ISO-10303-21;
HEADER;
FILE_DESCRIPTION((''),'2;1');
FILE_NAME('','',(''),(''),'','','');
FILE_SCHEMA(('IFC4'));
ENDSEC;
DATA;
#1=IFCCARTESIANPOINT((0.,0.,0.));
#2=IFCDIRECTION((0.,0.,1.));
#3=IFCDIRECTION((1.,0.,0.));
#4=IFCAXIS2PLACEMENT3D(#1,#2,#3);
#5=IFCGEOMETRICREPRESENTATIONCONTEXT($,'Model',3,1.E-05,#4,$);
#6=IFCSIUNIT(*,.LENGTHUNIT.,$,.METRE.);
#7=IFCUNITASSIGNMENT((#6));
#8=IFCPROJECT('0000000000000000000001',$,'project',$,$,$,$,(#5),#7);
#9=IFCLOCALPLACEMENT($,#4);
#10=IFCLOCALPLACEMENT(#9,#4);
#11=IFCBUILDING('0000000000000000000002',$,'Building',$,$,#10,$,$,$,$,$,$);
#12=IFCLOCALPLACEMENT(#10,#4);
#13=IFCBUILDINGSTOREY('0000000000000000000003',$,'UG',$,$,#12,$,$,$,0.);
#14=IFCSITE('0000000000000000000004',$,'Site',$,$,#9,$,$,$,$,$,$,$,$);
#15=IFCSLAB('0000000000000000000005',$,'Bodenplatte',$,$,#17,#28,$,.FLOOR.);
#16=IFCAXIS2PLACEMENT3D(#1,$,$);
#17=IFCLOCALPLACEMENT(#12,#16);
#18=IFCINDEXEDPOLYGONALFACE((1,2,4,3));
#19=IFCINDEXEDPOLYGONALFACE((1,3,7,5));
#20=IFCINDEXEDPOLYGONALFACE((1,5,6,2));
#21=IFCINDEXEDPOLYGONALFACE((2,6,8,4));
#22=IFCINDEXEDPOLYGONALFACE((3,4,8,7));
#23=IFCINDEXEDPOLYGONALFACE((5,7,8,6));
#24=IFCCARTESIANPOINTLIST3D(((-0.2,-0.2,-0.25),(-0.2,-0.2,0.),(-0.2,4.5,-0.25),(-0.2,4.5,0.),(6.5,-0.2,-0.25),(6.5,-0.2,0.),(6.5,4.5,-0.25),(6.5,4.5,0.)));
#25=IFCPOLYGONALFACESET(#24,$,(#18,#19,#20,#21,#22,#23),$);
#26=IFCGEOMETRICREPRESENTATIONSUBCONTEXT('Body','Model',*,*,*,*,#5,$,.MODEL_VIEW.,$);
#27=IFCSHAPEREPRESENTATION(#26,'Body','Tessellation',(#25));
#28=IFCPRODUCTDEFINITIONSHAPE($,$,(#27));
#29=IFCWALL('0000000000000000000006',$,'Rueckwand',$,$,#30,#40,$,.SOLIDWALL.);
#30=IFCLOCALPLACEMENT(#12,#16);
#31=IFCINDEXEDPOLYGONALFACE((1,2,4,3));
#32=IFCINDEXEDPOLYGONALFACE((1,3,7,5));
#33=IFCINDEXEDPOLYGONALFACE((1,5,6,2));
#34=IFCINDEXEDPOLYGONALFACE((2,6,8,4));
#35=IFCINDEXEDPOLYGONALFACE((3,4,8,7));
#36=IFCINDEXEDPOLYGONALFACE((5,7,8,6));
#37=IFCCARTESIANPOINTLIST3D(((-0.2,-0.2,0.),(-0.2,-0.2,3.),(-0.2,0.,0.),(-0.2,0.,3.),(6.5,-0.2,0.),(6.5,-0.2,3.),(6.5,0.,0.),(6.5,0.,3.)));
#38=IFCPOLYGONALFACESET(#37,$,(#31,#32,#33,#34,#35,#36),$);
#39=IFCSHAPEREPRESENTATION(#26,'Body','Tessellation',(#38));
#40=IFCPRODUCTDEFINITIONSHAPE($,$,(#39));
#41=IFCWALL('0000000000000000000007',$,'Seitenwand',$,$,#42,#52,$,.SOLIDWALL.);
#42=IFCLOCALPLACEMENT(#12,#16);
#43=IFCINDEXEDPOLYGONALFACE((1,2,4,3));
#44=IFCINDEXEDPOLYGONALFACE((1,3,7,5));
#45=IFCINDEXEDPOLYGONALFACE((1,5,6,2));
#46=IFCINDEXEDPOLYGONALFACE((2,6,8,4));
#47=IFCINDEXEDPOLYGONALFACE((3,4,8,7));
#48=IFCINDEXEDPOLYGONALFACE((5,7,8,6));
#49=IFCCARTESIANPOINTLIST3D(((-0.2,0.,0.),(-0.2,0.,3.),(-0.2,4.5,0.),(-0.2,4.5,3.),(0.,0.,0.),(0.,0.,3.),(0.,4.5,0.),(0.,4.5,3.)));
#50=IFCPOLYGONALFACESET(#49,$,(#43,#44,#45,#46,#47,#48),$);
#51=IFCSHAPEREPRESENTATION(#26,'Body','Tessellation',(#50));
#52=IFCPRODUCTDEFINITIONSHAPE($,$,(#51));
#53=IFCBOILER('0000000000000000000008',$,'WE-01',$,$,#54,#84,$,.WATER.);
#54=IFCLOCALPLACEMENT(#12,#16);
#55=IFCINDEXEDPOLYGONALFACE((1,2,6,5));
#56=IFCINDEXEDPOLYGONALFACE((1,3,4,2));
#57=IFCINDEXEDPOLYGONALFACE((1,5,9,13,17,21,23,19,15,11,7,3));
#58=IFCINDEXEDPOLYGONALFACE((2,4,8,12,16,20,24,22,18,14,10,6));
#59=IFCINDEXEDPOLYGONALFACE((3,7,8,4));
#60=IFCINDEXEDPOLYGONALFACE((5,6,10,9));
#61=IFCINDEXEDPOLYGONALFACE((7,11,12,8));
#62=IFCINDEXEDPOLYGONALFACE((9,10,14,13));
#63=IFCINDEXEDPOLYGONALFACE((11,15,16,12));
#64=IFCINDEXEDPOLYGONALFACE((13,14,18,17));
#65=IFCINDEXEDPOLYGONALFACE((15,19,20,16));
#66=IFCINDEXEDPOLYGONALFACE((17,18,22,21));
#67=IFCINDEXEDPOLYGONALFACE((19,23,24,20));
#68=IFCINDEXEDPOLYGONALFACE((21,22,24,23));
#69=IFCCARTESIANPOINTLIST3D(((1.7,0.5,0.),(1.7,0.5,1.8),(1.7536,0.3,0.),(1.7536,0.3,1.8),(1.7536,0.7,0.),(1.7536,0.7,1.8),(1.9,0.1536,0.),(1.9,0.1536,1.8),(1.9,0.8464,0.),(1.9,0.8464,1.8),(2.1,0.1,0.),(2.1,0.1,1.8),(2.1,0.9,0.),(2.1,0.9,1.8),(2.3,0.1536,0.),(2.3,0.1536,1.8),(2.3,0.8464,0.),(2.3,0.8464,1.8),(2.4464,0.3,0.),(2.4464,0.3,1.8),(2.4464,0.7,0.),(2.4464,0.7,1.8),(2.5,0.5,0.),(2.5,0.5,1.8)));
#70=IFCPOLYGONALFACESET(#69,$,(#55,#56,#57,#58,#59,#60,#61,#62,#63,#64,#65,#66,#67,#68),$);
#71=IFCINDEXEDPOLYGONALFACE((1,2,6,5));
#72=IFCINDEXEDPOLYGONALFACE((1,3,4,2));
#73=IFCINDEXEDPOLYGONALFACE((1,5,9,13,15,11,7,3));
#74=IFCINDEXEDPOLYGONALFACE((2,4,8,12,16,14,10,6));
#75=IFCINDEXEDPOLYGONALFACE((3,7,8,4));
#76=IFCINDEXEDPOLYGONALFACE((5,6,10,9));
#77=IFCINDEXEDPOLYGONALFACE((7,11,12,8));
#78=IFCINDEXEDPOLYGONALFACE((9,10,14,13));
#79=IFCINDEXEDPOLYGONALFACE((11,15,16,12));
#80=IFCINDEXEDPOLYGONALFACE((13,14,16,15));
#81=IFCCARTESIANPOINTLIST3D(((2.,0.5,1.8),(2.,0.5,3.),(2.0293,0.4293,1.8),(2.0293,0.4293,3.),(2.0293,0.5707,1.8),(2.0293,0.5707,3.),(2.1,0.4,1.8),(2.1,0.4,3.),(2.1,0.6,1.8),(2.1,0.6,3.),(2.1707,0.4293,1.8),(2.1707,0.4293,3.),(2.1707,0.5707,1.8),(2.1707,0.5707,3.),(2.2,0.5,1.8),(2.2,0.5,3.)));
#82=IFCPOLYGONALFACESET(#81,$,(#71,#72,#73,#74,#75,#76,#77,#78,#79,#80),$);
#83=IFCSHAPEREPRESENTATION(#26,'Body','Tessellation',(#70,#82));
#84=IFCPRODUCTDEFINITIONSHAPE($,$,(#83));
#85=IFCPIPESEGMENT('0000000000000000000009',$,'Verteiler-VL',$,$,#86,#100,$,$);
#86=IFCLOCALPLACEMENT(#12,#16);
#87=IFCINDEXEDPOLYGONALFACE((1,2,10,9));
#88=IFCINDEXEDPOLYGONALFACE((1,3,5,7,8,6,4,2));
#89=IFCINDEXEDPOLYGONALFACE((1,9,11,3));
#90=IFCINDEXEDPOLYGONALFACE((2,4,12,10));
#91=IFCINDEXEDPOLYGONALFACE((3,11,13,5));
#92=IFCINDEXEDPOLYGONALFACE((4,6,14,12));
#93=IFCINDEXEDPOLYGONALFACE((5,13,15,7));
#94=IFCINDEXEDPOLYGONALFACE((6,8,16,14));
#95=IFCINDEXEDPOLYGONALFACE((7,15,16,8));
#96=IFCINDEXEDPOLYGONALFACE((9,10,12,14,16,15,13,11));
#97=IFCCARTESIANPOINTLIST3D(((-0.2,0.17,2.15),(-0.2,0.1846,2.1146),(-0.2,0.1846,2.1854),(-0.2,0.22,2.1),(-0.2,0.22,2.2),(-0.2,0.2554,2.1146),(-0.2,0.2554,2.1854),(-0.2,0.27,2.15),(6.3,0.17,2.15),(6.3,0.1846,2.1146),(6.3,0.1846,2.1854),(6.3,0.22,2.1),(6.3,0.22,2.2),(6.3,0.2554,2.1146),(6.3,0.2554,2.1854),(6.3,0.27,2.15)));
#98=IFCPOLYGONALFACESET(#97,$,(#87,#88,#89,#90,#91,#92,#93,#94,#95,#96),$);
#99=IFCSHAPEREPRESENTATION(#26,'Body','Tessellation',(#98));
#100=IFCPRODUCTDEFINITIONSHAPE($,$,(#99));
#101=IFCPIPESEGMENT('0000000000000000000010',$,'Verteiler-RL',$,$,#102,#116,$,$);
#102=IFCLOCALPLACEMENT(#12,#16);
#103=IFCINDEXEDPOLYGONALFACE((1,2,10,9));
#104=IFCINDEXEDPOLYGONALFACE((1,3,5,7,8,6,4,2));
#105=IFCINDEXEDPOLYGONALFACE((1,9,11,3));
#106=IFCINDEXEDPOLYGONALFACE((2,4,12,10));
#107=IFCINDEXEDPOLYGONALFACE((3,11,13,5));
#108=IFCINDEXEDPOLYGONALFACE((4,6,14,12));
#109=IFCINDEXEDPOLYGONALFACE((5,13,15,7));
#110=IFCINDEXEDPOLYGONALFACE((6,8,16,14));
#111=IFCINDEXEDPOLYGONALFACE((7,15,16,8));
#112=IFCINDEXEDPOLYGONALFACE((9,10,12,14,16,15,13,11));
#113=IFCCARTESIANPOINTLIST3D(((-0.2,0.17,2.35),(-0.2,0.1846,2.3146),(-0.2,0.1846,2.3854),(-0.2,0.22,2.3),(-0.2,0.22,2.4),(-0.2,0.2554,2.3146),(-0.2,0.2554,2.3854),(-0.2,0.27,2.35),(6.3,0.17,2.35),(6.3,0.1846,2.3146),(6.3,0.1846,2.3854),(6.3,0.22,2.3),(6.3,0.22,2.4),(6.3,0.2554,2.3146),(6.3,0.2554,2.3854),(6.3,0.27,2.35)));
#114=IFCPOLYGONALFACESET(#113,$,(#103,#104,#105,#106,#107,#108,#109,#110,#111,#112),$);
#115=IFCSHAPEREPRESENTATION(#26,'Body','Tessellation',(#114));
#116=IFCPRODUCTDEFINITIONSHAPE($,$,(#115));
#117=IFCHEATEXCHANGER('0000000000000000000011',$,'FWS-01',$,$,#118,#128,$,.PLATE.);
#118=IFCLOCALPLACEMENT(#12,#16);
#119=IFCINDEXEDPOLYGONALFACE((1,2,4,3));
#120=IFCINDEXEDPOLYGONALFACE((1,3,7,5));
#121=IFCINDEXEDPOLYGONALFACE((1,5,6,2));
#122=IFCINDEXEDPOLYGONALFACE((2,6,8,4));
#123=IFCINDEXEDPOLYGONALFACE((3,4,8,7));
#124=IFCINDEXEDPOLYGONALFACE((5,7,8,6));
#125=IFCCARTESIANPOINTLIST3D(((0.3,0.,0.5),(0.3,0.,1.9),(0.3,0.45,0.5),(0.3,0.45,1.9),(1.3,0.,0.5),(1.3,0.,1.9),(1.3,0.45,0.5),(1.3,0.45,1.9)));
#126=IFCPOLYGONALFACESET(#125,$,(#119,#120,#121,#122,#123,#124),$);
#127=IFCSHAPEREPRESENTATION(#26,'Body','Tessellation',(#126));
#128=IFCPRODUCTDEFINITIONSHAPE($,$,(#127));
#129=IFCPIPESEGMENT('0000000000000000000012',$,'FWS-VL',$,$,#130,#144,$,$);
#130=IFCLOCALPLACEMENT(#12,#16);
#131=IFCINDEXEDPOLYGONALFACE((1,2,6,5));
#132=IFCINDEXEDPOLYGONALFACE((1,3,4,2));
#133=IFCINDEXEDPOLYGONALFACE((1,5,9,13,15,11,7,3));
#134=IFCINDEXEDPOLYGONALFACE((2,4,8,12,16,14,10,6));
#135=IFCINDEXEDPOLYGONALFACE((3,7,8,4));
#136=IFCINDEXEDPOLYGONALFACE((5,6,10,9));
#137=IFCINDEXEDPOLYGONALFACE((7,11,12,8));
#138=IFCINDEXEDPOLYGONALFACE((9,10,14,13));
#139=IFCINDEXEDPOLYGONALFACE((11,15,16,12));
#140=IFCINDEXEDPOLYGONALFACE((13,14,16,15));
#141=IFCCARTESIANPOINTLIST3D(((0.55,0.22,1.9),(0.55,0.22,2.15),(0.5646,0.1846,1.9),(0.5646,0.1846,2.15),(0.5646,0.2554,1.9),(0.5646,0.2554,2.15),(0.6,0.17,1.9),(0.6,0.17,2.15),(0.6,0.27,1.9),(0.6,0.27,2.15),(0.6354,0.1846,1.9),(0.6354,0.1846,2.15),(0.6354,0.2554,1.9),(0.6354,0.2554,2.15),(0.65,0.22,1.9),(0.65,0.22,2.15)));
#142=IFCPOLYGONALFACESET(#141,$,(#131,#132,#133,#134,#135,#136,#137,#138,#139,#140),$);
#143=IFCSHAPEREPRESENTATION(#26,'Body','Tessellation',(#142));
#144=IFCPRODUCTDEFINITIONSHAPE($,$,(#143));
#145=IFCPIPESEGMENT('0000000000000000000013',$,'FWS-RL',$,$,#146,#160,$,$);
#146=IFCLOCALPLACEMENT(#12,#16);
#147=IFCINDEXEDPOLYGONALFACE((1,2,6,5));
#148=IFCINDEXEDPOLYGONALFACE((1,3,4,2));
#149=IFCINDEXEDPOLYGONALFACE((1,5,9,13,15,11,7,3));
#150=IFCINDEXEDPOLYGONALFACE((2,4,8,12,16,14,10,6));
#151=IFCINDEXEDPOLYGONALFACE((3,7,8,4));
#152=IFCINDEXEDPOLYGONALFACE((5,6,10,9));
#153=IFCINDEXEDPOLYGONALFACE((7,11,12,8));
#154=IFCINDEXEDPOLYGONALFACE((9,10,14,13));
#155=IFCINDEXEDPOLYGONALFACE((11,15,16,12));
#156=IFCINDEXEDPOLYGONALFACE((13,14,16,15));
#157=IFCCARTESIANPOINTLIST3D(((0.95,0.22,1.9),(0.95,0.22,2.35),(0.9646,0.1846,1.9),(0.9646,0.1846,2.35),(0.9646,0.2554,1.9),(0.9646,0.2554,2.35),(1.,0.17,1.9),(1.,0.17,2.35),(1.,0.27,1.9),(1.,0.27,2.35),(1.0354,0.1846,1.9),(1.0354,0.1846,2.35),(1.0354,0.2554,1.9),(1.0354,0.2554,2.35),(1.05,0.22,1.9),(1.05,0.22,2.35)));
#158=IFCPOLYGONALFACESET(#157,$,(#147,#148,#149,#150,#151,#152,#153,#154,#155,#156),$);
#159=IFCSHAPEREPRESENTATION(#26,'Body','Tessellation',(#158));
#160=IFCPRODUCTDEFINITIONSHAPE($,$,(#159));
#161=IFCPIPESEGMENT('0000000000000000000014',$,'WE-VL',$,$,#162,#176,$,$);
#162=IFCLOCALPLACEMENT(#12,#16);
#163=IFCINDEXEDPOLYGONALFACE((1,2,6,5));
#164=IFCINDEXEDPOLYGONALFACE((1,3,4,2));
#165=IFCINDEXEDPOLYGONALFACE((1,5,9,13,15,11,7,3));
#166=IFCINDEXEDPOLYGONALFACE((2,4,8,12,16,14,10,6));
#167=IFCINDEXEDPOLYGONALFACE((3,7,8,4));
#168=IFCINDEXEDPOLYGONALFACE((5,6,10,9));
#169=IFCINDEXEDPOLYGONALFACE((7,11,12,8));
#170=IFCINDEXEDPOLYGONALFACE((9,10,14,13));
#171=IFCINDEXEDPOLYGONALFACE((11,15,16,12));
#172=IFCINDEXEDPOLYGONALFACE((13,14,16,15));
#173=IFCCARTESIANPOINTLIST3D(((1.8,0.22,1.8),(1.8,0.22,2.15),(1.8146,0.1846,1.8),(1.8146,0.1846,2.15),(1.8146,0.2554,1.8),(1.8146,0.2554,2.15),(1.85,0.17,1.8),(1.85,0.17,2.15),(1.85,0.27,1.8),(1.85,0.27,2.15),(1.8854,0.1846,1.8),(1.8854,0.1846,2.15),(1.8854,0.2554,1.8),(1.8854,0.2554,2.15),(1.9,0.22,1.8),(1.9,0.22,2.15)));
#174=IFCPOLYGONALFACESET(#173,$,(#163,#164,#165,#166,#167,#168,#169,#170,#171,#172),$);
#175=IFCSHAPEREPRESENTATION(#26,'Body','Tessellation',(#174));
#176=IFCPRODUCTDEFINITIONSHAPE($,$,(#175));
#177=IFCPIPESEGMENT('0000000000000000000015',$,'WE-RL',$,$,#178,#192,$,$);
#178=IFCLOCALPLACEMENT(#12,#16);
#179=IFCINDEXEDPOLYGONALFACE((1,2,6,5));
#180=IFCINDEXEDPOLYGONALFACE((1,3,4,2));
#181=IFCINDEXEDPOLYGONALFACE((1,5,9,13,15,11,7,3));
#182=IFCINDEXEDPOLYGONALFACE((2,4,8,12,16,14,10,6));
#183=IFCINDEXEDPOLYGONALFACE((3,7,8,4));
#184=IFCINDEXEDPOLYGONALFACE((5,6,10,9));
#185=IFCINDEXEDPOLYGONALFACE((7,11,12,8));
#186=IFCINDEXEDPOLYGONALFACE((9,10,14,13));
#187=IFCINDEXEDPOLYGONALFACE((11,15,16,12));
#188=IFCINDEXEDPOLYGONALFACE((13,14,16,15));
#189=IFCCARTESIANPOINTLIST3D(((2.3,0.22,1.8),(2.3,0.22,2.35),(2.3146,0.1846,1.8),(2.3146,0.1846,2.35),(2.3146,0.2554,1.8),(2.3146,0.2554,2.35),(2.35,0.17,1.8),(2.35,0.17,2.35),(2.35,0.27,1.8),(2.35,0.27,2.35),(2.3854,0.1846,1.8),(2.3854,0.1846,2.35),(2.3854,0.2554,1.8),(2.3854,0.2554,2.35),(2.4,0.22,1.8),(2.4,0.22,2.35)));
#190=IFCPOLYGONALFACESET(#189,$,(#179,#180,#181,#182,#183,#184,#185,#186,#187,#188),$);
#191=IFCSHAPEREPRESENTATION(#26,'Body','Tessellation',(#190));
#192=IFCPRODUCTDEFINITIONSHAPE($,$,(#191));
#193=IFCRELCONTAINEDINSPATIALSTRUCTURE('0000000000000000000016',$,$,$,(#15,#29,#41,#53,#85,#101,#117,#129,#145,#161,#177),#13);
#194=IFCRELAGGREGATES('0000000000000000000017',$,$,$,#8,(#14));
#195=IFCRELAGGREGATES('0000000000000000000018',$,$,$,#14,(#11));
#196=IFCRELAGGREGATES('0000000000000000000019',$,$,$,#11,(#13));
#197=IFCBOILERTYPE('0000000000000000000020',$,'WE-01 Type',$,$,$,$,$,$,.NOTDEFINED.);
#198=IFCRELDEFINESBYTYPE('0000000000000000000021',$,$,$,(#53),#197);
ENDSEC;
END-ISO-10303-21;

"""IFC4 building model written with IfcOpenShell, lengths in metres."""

from ifc_helpers import new_model, si_unit, frame, origin_with_axes, place, context, subcontext, project, spatial, polyline, outline, extrude, type_object, element, save


model = new_model("IFC4")

# Units and contexts
model_context = context("Model", 3, precision=1e-05, world=origin_with_axes())
body_context = subcontext(model_context, "Body", "Model", "MODEL_VIEW")
ifc_project = project(units=[si_unit("LENGTHUNIT", "METRE")], contexts=[model_context])

# Site, building, storey
site_placement = place(None, origin_with_axes())
site = spatial("IfcSite", under=ifc_project, at=site_placement, Name="Site")
building_placement = place(site_placement, origin_with_axes())
building = spatial("IfcBuilding", under=site, at=building_placement, Name="Building")
storey_placement = place(building_placement, origin_with_axes())
storey = spatial("IfcBuildingStorey", under=building, at=storey_placement, Name="UG", Elevation=0.0)

# Slab
slab_placement = place(storey_placement, frame((0.0, 0.0, -0.25), z_axis=(0.0, 0.0, 1.0), x_axis=(1.0, 0.0, 0.0)))
element("IfcSlab", 1, at=slab_placement, inside=storey, Name="Bodenplatte", PredefinedType="FLOOR", context=body_context, shape_type="SweptSolid", body=[
    extrude(outline(polyline([(-0.2, -0.2, 0.0), (6.5, -0.2, 0.0), (6.5, 4.5, 0.0), (-0.2, 4.5, 0.0), (-0.2, -0.2, 0.0)])), origin_with_axes(), (0.0, 0.0, 1.0), 0.25),
])

# Walls
wall_1_placement = place(storey_placement, frame((-0.2, -0.2, 0.0), z_axis=(0.0, 0.0, 1.0), x_axis=(1.0, 0.0, 0.0)))
element("IfcWall", 2, at=wall_1_placement, inside=storey, Name="Rueckwand", PredefinedType="SOLIDWALL", context=body_context, shape_type="SweptSolid", body=[
    extrude(outline(polyline([(0.0, 0.0, 0.0), (6.7, 0.0, 0.0), (6.7, 0.2, 0.0), (0.0, 0.2, 0.0), (0.0, 0.0, 0.0)])), origin_with_axes(), (0.0, 0.0, 1.0), 3.0),
])
wall_2_placement = place(storey_placement, frame((0.0, 0.0, 0.0), z_axis=(0.0, 0.0, 1.0), x_axis=(0.0, 1.0, 0.0)))
element("IfcWall", 3, at=wall_2_placement, inside=storey, Name="Seitenwand", PredefinedType="SOLIDWALL", context=body_context, shape_type="SweptSolid", body=[
    extrude(outline(polyline([(0.0, 0.0, 0.0), (4.5, 0.0, 0.0), (4.5, 0.2, 0.0), (0.0, 0.2, 0.0), (0.0, 0.0, 0.0)])), origin_with_axes(), (0.0, 0.0, 1.0), 3.0),
])

# Boiler
boiler_type = type_object("IfcBoilerType", Name="WE-01 Type", PredefinedType="NOTDEFINED")
boiler_placement = place(storey_placement, origin_with_axes())
element("IfcBoiler", 4, at=boiler_placement, inside=storey, type_object=boiler_type, Name="WE-01", PredefinedType="WATER", context=body_context, shape_type="SweptSolid", body=[
    extrude(outline(polyline([(0.4, 0.0, 0.0), (0.3464, 0.2, 0.0), (0.2, 0.3464, 0.0), (0.0, 0.4, 0.0), (-0.2, 0.3464, 0.0), (-0.3464, 0.2, 0.0), (-0.4, 0.0, 0.0), (-0.3464, -0.2, 0.0), (-0.2, -0.3464, 0.0), (0.0, -0.4, 0.0), (0.2, -0.3464, 0.0), (0.3464, -0.2, 0.0), (0.4, 0.0, 0.0)])), frame((2.1, 0.5, 0.0), z_axis=(0.0, 0.0, 1.0), x_axis=(1.0, 0.0, 0.0)), (0.0, 0.0, 1.0), 1.8),
    extrude(outline(polyline([(0.1, 0.0, 0.0), (0.0707, 0.0707, 0.0), (0.0, 0.1, 0.0), (-0.0707, 0.0707, 0.0), (-0.1, 0.0, 0.0), (-0.0707, -0.0707, 0.0), (0.0, -0.1, 0.0), (0.0707, -0.0707, 0.0), (0.1, 0.0, 0.0)])), frame((2.1, 0.5, 1.8), z_axis=(0.0, 0.0, 1.0), x_axis=(1.0, 0.0, 0.0)), (0.0, 0.0, 1.0), 1.2),
])

# Pipe segments
pipe_segment_1_placement = place(storey_placement, origin_with_axes())
element("IfcPipeSegment", 5, at=pipe_segment_1_placement, inside=storey, Name="Verteiler-VL", context=body_context, shape_type="SweptSolid", body=[
    extrude(outline(polyline([(0.05, 0.0, 0.0), (0.0354, 0.0354, 0.0), (0.0, 0.05, 0.0), (-0.0354, 0.0354, 0.0), (-0.05, 0.0, 0.0), (-0.0354, -0.0354, 0.0), (0.0, -0.05, 0.0), (0.0354, -0.0354, 0.0), (0.05, 0.0, 0.0)])), frame((-0.2, 0.22, 2.15), z_axis=(1.0, 0.0, 0.0), x_axis=(0.0, 1.0, 0.0)), (0.0, 0.0, 1.0), 6.5),
])
pipe_segment_2_placement = place(storey_placement, origin_with_axes())
element("IfcPipeSegment", 6, at=pipe_segment_2_placement, inside=storey, Name="Verteiler-RL", context=body_context, shape_type="SweptSolid", body=[
    extrude(outline(polyline([(0.05, 0.0, 0.0), (0.0354, 0.0354, 0.0), (0.0, 0.05, 0.0), (-0.0354, 0.0354, 0.0), (-0.05, 0.0, 0.0), (-0.0354, -0.0354, 0.0), (0.0, -0.05, 0.0), (0.0354, -0.0354, 0.0), (0.05, 0.0, 0.0)])), frame((-0.2, 0.22, 2.35), z_axis=(1.0, 0.0, 0.0), x_axis=(0.0, 1.0, 0.0)), (0.0, 0.0, 1.0), 6.5),
])

# Heat exchanger
heat_exchanger_placement = place(storey_placement, origin_with_axes())
element("IfcHeatExchanger", 7, at=heat_exchanger_placement, inside=storey, Name="FWS-01", PredefinedType="PLATE", context=body_context, shape_type="SweptSolid", body=[
    extrude(outline(polyline([(0.3, 0.0, 0.0), (1.3, 0.0, 0.0), (1.3, 0.45, 0.0), (0.3, 0.45, 0.0), (0.3, 0.0, 0.0)])), frame((0.0, 0.0, 0.5), z_axis=(0.0, 0.0, 1.0), x_axis=(1.0, 0.0, 0.0)), (0.0, 0.0, 1.0), 1.4),
])

# Pipe segments
pipe_segment_3_placement = place(storey_placement, origin_with_axes())
element("IfcPipeSegment", 8, at=pipe_segment_3_placement, inside=storey, Name="FWS-VL", context=body_context, shape_type="SweptSolid", body=[
    extrude(outline(polyline([(0.05, 0.0, 0.0), (0.0354, 0.0354, 0.0), (0.0, 0.05, 0.0), (-0.0354, 0.0354, 0.0), (-0.05, 0.0, 0.0), (-0.0354, -0.0354, 0.0), (0.0, -0.05, 0.0), (0.0354, -0.0354, 0.0), (0.05, 0.0, 0.0)])), frame((0.6, 0.22, 1.9), z_axis=(0.0, 0.0, 1.0), x_axis=(1.0, 0.0, 0.0)), (0.0, 0.0, 1.0), 0.25),
])
pipe_segment_4_placement = place(storey_placement, origin_with_axes())
element("IfcPipeSegment", 9, at=pipe_segment_4_placement, inside=storey, Name="FWS-RL", context=body_context, shape_type="SweptSolid", body=[
    extrude(outline(polyline([(0.05, 0.0, 0.0), (0.0354, 0.0354, 0.0), (0.0, 0.05, 0.0), (-0.0354, 0.0354, 0.0), (-0.05, 0.0, 0.0), (-0.0354, -0.0354, 0.0), (0.0, -0.05, 0.0), (0.0354, -0.0354, 0.0), (0.05, 0.0, 0.0)])), frame((1.0, 0.22, 1.9), z_axis=(0.0, 0.0, 1.0), x_axis=(1.0, 0.0, 0.0)), (0.0, 0.0, 1.0), 0.45),
])
pipe_segment_5_placement = place(storey_placement, origin_with_axes())
element("IfcPipeSegment", 10, at=pipe_segment_5_placement, inside=storey, Name="WE-VL", context=body_context, shape_type="SweptSolid", body=[
    extrude(outline(polyline([(0.05, 0.0, 0.0), (0.0354, 0.0354, 0.0), (0.0, 0.05, 0.0), (-0.0354, 0.0354, 0.0), (-0.05, 0.0, 0.0), (-0.0354, -0.0354, 0.0), (0.0, -0.05, 0.0), (0.0354, -0.0354, 0.0), (0.05, 0.0, 0.0)])), frame((1.85, 0.22, 1.8), z_axis=(0.0, 0.0, 1.0), x_axis=(1.0, 0.0, 0.0)), (0.0, 0.0, 1.0), 0.35),
])
pipe_segment_6_placement = place(storey_placement, origin_with_axes())
element("IfcPipeSegment", 11, at=pipe_segment_6_placement, inside=storey, Name="WE-RL", context=body_context, shape_type="SweptSolid", body=[
    extrude(outline(polyline([(0.05, 0.0, 0.0), (0.0354, 0.0354, 0.0), (0.0, 0.05, 0.0), (-0.0354, 0.0354, 0.0), (-0.05, 0.0, 0.0), (-0.0354, -0.0354, 0.0), (0.0, -0.05, 0.0), (0.0354, -0.0354, 0.0), (0.05, 0.0, 0.0)])), frame((2.35, 0.22, 1.8), z_axis=(0.0, 0.0, 1.0), x_axis=(1.0, 0.0, 0.0)), (0.0, 0.0, 1.0), 0.55),
])

save(model, "model.ifc")
